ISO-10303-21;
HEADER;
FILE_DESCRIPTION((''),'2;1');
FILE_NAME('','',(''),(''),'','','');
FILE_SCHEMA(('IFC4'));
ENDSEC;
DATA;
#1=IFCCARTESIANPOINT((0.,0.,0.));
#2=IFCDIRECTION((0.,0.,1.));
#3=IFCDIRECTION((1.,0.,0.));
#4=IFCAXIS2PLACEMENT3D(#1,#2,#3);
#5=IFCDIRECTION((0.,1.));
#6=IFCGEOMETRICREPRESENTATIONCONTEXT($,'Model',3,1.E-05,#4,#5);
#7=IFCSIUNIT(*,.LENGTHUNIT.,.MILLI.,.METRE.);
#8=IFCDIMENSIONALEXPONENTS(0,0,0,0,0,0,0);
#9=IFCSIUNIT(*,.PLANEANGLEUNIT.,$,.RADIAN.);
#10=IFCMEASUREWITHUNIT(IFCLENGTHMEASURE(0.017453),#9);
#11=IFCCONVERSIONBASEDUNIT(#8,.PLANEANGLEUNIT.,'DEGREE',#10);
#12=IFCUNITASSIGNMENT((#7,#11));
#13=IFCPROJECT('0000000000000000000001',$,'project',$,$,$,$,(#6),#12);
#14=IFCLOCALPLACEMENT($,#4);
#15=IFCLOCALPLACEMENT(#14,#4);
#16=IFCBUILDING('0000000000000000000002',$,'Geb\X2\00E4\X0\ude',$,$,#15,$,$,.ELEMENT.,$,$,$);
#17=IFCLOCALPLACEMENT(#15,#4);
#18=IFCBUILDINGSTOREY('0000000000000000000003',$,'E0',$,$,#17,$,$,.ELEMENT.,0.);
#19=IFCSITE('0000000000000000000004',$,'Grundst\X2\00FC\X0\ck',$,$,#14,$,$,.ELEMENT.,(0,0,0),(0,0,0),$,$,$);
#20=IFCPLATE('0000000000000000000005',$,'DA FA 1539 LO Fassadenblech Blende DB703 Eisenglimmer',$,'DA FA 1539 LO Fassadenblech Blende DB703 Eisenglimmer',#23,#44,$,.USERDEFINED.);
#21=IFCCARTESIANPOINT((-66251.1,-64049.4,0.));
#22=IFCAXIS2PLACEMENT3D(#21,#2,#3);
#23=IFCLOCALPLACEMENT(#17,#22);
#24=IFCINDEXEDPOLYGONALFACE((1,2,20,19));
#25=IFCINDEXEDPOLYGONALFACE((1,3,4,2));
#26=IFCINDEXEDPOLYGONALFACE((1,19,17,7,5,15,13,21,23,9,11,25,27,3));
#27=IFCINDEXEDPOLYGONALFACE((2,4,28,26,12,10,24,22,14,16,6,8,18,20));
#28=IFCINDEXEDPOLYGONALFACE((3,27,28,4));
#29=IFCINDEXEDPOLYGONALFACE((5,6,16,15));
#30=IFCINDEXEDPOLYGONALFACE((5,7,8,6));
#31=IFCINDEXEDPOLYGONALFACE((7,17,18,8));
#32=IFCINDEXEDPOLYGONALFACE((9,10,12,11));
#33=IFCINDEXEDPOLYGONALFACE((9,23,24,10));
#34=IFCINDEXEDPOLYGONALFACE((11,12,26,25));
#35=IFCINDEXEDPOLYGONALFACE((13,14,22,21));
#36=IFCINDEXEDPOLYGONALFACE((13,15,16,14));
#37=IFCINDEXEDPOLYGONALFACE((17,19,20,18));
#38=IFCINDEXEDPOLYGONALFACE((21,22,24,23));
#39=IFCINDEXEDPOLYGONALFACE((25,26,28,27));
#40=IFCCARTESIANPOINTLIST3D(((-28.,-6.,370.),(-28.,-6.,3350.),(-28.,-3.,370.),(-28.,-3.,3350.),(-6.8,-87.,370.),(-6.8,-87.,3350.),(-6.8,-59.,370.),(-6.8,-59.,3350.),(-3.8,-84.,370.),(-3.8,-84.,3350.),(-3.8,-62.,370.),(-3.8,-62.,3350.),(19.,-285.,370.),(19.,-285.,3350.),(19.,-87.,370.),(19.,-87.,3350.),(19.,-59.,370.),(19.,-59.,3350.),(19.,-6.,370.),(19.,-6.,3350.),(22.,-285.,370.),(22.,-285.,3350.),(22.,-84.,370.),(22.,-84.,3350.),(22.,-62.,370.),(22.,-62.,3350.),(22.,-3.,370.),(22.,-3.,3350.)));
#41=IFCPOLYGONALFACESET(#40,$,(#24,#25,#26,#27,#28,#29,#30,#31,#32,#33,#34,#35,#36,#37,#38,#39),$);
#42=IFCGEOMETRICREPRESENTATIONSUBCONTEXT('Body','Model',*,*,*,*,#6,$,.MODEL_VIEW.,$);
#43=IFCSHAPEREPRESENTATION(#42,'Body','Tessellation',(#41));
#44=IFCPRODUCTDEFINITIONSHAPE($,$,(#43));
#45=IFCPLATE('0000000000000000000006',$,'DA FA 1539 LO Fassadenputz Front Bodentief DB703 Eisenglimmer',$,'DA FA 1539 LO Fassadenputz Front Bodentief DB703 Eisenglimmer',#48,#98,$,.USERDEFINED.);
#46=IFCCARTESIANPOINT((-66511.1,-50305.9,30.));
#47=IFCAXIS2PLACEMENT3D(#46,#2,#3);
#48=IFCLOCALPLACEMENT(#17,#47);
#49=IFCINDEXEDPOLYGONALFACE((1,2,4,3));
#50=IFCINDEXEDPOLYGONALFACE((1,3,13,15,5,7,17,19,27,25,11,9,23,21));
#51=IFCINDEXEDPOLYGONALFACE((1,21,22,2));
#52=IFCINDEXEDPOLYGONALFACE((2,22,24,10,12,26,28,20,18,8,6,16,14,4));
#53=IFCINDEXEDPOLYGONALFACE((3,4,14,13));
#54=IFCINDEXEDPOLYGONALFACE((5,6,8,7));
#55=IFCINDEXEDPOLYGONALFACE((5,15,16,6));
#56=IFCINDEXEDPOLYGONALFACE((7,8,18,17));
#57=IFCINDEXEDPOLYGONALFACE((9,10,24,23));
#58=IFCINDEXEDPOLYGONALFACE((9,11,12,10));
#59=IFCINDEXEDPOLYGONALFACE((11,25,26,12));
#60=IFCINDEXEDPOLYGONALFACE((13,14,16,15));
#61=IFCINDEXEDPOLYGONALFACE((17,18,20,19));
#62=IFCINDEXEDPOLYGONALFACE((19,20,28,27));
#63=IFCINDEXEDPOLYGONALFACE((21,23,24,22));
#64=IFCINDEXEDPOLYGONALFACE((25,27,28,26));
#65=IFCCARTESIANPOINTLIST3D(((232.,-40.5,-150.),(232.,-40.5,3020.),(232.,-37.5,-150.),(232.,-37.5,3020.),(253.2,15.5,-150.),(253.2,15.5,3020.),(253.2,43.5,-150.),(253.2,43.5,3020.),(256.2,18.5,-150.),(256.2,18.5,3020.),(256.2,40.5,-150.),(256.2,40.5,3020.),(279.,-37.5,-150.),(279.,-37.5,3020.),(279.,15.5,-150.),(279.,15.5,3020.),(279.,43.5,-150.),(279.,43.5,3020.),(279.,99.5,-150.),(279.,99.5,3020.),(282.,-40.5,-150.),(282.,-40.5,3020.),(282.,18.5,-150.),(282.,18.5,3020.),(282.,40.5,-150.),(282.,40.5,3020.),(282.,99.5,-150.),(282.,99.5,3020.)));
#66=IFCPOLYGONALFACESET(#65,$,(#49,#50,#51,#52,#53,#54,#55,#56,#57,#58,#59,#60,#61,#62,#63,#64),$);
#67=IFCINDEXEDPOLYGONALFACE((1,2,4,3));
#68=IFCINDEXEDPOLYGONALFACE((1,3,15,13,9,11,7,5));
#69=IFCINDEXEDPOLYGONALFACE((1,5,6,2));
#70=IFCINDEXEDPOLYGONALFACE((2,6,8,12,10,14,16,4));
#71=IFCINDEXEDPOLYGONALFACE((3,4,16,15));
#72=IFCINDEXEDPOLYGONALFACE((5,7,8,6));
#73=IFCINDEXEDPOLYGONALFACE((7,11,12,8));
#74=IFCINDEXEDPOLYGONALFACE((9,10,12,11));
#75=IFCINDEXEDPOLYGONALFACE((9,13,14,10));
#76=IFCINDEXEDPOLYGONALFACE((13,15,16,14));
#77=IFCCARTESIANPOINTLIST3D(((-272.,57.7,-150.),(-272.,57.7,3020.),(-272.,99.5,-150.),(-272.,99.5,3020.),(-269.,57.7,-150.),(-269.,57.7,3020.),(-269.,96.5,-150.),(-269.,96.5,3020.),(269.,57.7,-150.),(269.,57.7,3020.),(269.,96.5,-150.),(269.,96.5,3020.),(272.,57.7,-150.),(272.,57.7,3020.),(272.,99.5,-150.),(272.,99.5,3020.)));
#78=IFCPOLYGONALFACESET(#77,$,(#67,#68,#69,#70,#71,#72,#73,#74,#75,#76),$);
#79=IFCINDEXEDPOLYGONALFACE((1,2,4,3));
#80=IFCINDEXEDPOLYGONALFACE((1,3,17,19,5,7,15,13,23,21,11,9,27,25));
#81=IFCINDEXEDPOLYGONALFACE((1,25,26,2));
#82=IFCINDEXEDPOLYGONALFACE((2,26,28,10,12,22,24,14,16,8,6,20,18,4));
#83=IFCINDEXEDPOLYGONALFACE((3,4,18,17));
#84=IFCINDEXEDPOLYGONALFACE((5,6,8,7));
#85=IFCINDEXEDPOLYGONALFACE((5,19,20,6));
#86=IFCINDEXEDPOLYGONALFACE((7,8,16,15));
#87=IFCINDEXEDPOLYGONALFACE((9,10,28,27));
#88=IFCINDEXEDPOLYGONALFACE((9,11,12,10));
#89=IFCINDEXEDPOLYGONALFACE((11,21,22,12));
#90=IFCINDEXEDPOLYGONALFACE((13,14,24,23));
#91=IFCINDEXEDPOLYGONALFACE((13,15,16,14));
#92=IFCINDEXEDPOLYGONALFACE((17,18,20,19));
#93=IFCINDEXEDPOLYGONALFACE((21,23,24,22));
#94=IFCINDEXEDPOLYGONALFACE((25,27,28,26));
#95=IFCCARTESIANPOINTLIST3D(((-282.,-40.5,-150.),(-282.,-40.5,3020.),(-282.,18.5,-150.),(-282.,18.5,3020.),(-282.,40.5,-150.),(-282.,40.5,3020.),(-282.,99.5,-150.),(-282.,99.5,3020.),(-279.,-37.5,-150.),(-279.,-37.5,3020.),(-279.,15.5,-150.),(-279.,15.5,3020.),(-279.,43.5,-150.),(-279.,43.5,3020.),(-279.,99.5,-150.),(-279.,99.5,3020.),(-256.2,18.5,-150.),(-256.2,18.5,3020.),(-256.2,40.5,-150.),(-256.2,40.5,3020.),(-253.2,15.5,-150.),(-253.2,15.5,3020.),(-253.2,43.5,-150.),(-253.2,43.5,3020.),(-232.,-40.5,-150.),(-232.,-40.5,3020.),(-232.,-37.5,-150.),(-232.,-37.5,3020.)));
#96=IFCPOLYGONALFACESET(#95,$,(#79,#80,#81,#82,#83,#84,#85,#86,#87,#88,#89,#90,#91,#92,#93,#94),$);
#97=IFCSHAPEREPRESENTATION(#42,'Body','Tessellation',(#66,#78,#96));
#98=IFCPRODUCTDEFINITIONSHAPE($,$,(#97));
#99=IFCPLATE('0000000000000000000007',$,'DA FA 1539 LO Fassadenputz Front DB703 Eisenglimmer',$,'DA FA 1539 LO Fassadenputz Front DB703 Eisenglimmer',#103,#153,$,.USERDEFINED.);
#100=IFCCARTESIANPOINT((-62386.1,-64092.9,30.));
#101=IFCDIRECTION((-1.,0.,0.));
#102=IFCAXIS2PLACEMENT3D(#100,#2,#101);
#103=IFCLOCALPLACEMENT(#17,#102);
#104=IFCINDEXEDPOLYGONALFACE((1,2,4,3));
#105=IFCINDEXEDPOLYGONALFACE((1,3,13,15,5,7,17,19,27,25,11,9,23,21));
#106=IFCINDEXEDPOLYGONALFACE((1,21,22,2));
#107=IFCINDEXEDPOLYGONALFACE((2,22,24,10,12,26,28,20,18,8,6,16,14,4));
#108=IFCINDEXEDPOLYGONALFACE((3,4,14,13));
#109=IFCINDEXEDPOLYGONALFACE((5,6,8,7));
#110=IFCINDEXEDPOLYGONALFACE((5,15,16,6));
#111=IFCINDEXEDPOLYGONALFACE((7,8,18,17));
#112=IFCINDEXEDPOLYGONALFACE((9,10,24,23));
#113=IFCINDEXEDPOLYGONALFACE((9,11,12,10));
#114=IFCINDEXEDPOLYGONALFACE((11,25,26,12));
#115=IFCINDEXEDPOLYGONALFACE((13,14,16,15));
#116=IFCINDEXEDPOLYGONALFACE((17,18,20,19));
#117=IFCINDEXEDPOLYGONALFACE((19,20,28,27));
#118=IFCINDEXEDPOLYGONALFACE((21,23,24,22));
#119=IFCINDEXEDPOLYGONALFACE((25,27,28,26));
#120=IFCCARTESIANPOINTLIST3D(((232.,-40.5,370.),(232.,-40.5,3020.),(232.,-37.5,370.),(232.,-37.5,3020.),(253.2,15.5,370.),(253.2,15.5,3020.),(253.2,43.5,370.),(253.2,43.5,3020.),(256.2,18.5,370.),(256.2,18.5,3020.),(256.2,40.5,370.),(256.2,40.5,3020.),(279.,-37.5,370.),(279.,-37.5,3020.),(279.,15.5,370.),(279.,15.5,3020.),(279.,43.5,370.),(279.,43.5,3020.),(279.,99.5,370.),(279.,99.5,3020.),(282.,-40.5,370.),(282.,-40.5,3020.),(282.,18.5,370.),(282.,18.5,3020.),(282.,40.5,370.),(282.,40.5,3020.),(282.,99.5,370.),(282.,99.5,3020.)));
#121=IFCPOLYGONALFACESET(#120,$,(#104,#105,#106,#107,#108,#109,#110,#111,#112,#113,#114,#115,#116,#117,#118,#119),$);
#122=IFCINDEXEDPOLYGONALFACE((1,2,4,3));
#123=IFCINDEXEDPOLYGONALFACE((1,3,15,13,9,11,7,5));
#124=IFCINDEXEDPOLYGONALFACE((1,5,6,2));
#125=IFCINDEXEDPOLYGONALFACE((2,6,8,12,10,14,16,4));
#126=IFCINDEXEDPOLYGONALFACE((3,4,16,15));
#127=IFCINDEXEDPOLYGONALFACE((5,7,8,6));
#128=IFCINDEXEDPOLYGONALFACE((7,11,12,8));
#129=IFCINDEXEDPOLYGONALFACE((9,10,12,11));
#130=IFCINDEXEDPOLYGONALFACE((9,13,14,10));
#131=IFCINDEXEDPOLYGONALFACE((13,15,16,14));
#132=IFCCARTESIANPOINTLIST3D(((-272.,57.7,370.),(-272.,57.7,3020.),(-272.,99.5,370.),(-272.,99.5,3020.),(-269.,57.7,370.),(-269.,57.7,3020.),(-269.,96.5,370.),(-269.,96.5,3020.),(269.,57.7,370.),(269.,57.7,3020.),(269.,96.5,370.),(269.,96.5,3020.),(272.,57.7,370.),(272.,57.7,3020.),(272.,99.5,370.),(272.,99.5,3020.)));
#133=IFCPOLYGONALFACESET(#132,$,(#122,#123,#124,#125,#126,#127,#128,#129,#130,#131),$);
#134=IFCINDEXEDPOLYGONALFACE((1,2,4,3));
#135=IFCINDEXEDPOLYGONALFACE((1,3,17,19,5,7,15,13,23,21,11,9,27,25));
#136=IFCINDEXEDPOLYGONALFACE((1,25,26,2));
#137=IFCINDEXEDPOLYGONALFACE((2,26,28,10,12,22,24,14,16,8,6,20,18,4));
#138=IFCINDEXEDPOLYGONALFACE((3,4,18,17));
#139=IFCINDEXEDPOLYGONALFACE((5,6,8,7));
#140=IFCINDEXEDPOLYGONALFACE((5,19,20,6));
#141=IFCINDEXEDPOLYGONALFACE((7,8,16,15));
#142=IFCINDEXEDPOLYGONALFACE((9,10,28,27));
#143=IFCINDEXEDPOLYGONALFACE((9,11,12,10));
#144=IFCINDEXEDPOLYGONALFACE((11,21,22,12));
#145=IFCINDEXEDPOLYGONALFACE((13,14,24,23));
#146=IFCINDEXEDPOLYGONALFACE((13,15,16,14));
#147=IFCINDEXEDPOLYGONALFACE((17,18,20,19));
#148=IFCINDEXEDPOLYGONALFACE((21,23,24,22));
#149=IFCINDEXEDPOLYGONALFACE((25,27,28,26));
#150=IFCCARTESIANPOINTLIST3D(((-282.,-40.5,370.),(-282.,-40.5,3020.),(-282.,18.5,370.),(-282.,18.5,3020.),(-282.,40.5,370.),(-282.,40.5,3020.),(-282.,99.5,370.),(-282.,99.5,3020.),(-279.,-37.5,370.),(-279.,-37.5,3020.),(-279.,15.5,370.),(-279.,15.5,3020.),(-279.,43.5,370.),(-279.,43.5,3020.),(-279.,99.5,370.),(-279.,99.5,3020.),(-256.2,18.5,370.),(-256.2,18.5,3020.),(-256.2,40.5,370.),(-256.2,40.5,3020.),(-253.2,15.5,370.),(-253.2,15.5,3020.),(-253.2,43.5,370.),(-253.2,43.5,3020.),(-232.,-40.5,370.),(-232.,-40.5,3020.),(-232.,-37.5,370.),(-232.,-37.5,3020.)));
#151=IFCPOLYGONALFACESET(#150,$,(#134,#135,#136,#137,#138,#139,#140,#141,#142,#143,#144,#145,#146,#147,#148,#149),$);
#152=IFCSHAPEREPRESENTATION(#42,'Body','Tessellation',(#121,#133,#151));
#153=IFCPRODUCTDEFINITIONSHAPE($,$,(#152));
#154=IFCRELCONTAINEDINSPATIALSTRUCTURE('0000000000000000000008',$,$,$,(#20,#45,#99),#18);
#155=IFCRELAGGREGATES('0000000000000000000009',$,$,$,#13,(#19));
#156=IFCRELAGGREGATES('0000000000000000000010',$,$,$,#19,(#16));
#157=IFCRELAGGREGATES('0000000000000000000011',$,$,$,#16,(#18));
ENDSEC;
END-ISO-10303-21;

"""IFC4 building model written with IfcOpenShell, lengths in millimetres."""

from ifc_helpers import new_model, entity, si_unit, converted_unit, direction, frame, origin_with_axes, place, context, subcontext, project, spatial, line, indexed_curve, outline, extrude, source, transform, mapped, element, save


model = new_model("IFC4")

# Units and contexts
model_context = context("Model", 3, precision=1e-05, world=origin_with_axes(), true_north=direction((0.0, 1.0)))
body_context = subcontext(model_context, "Body", "Model", "MODEL_VIEW")
ifc_project = project(units=[si_unit("LENGTHUNIT", "METRE", prefix="MILLI"), converted_unit("PLANEANGLEUNIT", "DEGREE", entity("IfcLengthMeasure", 0.017453), si_unit("PLANEANGLEUNIT", "RADIAN"), dimensions=[0, 0, 0, 0, 0, 0, 0])], contexts=[model_context])

# Site, building, storey
site_placement = place(None, origin_with_axes())
site = spatial("IfcSite", under=ifc_project, at=site_placement, Name="Grundstück", CompositionType="ELEMENT", RefLatitude=(0, 0, 0), RefLongitude=(0, 0, 0))
building_placement = place(site_placement, origin_with_axes())
building = spatial("IfcBuilding", under=site, at=building_placement, Name="Gebäude", CompositionType="ELEMENT")
storey_placement = place(building_placement, origin_with_axes())
storey = spatial("IfcBuildingStorey", under=building, at=storey_placement, Name="E0", CompositionType="ELEMENT", Elevation=0.0)

# Plates
shared_shape_1 = source(origin_with_axes(), body_context, "Body", "SweptSolid", [
    extrude(outline(indexed_curve([(22.0, 285.0), (22.0, 84.0), (-3.8, 84.0), (-3.8, 62.0), (22.0, 62.0), (22.0, 3.0), (-28.0, 3.0), (-28.0, 6.0), (19.0, 6.0), (19.0, 59.0), (-6.8, 59.0), (-6.8, 87.0), (19.0, 87.0), (19.0, 285.0)], segments=[line(1, 2), line(2, 3), line(3, 4), line(4, 5), line(5, 6), line(6, 7), line(7, 8), line(8, 9), line(9, 10), line(10, 11), line(11, 12), line(12, 13), line(13, 14), line(14, 1)])), frame((0.0, 0.0, 370.0), z_axis=(0.0, 0.0, 1.0), x_axis=(1.0, 0.0, 0.0)), (0.0, 0.0, 1.0), 2980.0),
])
plate_1_placement = place(storey_placement, frame((-66251.1, -64049.4, 0.0), z_axis=(0.0, 0.0, 1.0), x_axis=(1.0, 0.0, 0.0)))
element("IfcPlate", 1, at=plate_1_placement, inside=storey, Name="DA FA 1539 LO Fassadenblech Blende DB703 Eisenglimmer", ObjectType="DA FA 1539 LO Fassadenblech Blende DB703 Eisenglimmer", PredefinedType="USERDEFINED", context=body_context, shape_type="MappedRepresentation", body=[
    mapped(shared_shape_1, transform((0.0, 0.0, 0.0), x_axis=(1.0, 0.0, 0.0), y_axis=(0.0, -1.0, 0.0), z_axis=(0.0, 0.0, 1.0), scale=1.0)),
])
shared_shape_2 = source(origin_with_axes(), body_context, "Body", "SweptSolid", [
    extrude(outline(indexed_curve([(282.0, 99.5), (282.0, 40.5), (256.2, 40.5), (256.2, 18.5), (282.0, 18.5), (282.0, -40.5), (232.0, -40.5), (232.0, -37.5), (279.0, -37.5), (279.0, 15.5), (253.2, 15.5), (253.2, 43.5), (279.0, 43.5), (279.0, 99.5)], segments=[line(1, 2), line(2, 3), line(3, 4), line(4, 5), line(5, 6), line(6, 7), line(7, 8), line(8, 9), line(9, 10), line(10, 11), line(11, 12), line(12, 13), line(13, 14), line(14, 1)])), frame((0.0, 0.0, -150.0), z_axis=(0.0, 0.0, 1.0), x_axis=(1.0, 0.0, 0.0)), (0.0, 0.0, 1.0), 3170.0),
    extrude(outline(indexed_curve([(272.0, 99.5), (272.0, 57.7), (269.0, 57.7), (269.0, 96.5), (-269.0, 96.5), (-269.0, 57.7), (-272.0, 57.7), (-272.0, 99.5)], segments=[line(1, 2), line(2, 3), line(3, 4), line(4, 5), line(5, 6), line(6, 7), line(7, 8), line(8, 1)])), frame((0.0, 0.0, -150.0), z_axis=(0.0, 0.0, 1.0), x_axis=(1.0, 0.0, 0.0)), (0.0, 0.0, 1.0), 3170.0),
    extrude(outline(indexed_curve([(-282.0, 99.5), (-282.0, 40.5), (-256.2, 40.5), (-256.2, 18.5), (-282.0, 18.5), (-282.0, -40.5), (-232.0, -40.5), (-232.0, -37.5), (-279.0, -37.5), (-279.0, 15.5), (-253.2, 15.5), (-253.2, 43.5), (-279.0, 43.5), (-279.0, 99.5)], segments=[line(1, 2), line(2, 3), line(3, 4), line(4, 5), line(5, 6), line(6, 7), line(7, 8), line(8, 9), line(9, 10), line(10, 11), line(11, 12), line(12, 13), line(13, 14), line(14, 1)])), frame((0.0, 0.0, -150.0), z_axis=(0.0, 0.0, 1.0), x_axis=(1.0, 0.0, 0.0)), (0.0, 0.0, 1.0), 3170.0),
])
plate_2_placement = place(storey_placement, frame((-66511.1, -50305.9, 30.0), z_axis=(0.0, 0.0, 1.0), x_axis=(1.0, 0.0, 0.0)))
element("IfcPlate", 2, at=plate_2_placement, inside=storey, Name="DA FA 1539 LO Fassadenputz Front Bodentief DB703 Eisenglimmer", ObjectType="DA FA 1539 LO Fassadenputz Front Bodentief DB703 Eisenglimmer", PredefinedType="USERDEFINED", context=body_context, shape_type="MappedRepresentation", body=[
    mapped(shared_shape_2, transform((0.0, 0.0, 0.0), x_axis=(1.0, 0.0, 0.0), y_axis=(0.0, 1.0, 0.0), z_axis=(0.0, 0.0, 1.0), scale=1.0)),
])
plate_3_placement = place(storey_placement, frame((-62386.1, -64092.9, 30.0), z_axis=(0.0, 0.0, 1.0), x_axis=(-1.0, 0.0, 0.0)))
element("IfcPlate", 3, at=plate_3_placement, inside=storey, Name="DA FA 1539 LO Fassadenputz Front DB703 Eisenglimmer", ObjectType="DA FA 1539 LO Fassadenputz Front DB703 Eisenglimmer", PredefinedType="USERDEFINED", context=body_context, shape_type="SweptSolid", body=[
    extrude(outline(indexed_curve([(282.0, 99.5), (282.0, 40.5), (256.2, 40.5), (256.2, 18.5), (282.0, 18.5), (282.0, -40.5), (232.0, -40.5), (232.0, -37.5), (279.0, -37.5), (279.0, 15.5), (253.2, 15.5), (253.2, 43.5), (279.0, 43.5), (279.0, 99.5)], segments=[line(1, 2), line(2, 3), line(3, 4), line(4, 5), line(5, 6), line(6, 7), line(7, 8), line(8, 9), line(9, 10), line(10, 11), line(11, 12), line(12, 13), line(13, 14), line(14, 1)])), frame((0.0, 0.0, 370.0), z_axis=(0.0, 0.0, 1.0), x_axis=(1.0, 0.0, 0.0)), (0.0, 0.0, 1.0), 2650.0),
    extrude(outline(indexed_curve([(272.0, 99.5), (272.0, 57.7), (269.0, 57.7), (269.0, 96.5), (-269.0, 96.5), (-269.0, 57.7), (-272.0, 57.7), (-272.0, 99.5)], segments=[line(1, 2), line(2, 3), line(3, 4), line(4, 5), line(5, 6), line(6, 7), line(7, 8), line(8, 1)])), frame((0.0, 0.0, 370.0), z_axis=(0.0, 0.0, 1.0), x_axis=(1.0, 0.0, 0.0)), (0.0, 0.0, 1.0), 2650.0),
    extrude(outline(indexed_curve([(-282.0, 99.5), (-282.0, 40.5), (-256.2, 40.5), (-256.2, 18.5), (-282.0, 18.5), (-282.0, -40.5), (-232.0, -40.5), (-232.0, -37.5), (-279.0, -37.5), (-279.0, 15.5), (-253.2, 15.5), (-253.2, 43.5), (-279.0, 43.5), (-279.0, 99.5)], segments=[line(1, 2), line(2, 3), line(3, 4), line(4, 5), line(5, 6), line(6, 7), line(7, 8), line(8, 9), line(9, 10), line(10, 11), line(11, 12), line(12, 13), line(13, 14), line(14, 1)])), frame((0.0, 0.0, 370.0), z_axis=(0.0, 0.0, 1.0), x_axis=(1.0, 0.0, 0.0)), (0.0, 0.0, 1.0), 2650.0),
])

save(model, "model.ifc")
